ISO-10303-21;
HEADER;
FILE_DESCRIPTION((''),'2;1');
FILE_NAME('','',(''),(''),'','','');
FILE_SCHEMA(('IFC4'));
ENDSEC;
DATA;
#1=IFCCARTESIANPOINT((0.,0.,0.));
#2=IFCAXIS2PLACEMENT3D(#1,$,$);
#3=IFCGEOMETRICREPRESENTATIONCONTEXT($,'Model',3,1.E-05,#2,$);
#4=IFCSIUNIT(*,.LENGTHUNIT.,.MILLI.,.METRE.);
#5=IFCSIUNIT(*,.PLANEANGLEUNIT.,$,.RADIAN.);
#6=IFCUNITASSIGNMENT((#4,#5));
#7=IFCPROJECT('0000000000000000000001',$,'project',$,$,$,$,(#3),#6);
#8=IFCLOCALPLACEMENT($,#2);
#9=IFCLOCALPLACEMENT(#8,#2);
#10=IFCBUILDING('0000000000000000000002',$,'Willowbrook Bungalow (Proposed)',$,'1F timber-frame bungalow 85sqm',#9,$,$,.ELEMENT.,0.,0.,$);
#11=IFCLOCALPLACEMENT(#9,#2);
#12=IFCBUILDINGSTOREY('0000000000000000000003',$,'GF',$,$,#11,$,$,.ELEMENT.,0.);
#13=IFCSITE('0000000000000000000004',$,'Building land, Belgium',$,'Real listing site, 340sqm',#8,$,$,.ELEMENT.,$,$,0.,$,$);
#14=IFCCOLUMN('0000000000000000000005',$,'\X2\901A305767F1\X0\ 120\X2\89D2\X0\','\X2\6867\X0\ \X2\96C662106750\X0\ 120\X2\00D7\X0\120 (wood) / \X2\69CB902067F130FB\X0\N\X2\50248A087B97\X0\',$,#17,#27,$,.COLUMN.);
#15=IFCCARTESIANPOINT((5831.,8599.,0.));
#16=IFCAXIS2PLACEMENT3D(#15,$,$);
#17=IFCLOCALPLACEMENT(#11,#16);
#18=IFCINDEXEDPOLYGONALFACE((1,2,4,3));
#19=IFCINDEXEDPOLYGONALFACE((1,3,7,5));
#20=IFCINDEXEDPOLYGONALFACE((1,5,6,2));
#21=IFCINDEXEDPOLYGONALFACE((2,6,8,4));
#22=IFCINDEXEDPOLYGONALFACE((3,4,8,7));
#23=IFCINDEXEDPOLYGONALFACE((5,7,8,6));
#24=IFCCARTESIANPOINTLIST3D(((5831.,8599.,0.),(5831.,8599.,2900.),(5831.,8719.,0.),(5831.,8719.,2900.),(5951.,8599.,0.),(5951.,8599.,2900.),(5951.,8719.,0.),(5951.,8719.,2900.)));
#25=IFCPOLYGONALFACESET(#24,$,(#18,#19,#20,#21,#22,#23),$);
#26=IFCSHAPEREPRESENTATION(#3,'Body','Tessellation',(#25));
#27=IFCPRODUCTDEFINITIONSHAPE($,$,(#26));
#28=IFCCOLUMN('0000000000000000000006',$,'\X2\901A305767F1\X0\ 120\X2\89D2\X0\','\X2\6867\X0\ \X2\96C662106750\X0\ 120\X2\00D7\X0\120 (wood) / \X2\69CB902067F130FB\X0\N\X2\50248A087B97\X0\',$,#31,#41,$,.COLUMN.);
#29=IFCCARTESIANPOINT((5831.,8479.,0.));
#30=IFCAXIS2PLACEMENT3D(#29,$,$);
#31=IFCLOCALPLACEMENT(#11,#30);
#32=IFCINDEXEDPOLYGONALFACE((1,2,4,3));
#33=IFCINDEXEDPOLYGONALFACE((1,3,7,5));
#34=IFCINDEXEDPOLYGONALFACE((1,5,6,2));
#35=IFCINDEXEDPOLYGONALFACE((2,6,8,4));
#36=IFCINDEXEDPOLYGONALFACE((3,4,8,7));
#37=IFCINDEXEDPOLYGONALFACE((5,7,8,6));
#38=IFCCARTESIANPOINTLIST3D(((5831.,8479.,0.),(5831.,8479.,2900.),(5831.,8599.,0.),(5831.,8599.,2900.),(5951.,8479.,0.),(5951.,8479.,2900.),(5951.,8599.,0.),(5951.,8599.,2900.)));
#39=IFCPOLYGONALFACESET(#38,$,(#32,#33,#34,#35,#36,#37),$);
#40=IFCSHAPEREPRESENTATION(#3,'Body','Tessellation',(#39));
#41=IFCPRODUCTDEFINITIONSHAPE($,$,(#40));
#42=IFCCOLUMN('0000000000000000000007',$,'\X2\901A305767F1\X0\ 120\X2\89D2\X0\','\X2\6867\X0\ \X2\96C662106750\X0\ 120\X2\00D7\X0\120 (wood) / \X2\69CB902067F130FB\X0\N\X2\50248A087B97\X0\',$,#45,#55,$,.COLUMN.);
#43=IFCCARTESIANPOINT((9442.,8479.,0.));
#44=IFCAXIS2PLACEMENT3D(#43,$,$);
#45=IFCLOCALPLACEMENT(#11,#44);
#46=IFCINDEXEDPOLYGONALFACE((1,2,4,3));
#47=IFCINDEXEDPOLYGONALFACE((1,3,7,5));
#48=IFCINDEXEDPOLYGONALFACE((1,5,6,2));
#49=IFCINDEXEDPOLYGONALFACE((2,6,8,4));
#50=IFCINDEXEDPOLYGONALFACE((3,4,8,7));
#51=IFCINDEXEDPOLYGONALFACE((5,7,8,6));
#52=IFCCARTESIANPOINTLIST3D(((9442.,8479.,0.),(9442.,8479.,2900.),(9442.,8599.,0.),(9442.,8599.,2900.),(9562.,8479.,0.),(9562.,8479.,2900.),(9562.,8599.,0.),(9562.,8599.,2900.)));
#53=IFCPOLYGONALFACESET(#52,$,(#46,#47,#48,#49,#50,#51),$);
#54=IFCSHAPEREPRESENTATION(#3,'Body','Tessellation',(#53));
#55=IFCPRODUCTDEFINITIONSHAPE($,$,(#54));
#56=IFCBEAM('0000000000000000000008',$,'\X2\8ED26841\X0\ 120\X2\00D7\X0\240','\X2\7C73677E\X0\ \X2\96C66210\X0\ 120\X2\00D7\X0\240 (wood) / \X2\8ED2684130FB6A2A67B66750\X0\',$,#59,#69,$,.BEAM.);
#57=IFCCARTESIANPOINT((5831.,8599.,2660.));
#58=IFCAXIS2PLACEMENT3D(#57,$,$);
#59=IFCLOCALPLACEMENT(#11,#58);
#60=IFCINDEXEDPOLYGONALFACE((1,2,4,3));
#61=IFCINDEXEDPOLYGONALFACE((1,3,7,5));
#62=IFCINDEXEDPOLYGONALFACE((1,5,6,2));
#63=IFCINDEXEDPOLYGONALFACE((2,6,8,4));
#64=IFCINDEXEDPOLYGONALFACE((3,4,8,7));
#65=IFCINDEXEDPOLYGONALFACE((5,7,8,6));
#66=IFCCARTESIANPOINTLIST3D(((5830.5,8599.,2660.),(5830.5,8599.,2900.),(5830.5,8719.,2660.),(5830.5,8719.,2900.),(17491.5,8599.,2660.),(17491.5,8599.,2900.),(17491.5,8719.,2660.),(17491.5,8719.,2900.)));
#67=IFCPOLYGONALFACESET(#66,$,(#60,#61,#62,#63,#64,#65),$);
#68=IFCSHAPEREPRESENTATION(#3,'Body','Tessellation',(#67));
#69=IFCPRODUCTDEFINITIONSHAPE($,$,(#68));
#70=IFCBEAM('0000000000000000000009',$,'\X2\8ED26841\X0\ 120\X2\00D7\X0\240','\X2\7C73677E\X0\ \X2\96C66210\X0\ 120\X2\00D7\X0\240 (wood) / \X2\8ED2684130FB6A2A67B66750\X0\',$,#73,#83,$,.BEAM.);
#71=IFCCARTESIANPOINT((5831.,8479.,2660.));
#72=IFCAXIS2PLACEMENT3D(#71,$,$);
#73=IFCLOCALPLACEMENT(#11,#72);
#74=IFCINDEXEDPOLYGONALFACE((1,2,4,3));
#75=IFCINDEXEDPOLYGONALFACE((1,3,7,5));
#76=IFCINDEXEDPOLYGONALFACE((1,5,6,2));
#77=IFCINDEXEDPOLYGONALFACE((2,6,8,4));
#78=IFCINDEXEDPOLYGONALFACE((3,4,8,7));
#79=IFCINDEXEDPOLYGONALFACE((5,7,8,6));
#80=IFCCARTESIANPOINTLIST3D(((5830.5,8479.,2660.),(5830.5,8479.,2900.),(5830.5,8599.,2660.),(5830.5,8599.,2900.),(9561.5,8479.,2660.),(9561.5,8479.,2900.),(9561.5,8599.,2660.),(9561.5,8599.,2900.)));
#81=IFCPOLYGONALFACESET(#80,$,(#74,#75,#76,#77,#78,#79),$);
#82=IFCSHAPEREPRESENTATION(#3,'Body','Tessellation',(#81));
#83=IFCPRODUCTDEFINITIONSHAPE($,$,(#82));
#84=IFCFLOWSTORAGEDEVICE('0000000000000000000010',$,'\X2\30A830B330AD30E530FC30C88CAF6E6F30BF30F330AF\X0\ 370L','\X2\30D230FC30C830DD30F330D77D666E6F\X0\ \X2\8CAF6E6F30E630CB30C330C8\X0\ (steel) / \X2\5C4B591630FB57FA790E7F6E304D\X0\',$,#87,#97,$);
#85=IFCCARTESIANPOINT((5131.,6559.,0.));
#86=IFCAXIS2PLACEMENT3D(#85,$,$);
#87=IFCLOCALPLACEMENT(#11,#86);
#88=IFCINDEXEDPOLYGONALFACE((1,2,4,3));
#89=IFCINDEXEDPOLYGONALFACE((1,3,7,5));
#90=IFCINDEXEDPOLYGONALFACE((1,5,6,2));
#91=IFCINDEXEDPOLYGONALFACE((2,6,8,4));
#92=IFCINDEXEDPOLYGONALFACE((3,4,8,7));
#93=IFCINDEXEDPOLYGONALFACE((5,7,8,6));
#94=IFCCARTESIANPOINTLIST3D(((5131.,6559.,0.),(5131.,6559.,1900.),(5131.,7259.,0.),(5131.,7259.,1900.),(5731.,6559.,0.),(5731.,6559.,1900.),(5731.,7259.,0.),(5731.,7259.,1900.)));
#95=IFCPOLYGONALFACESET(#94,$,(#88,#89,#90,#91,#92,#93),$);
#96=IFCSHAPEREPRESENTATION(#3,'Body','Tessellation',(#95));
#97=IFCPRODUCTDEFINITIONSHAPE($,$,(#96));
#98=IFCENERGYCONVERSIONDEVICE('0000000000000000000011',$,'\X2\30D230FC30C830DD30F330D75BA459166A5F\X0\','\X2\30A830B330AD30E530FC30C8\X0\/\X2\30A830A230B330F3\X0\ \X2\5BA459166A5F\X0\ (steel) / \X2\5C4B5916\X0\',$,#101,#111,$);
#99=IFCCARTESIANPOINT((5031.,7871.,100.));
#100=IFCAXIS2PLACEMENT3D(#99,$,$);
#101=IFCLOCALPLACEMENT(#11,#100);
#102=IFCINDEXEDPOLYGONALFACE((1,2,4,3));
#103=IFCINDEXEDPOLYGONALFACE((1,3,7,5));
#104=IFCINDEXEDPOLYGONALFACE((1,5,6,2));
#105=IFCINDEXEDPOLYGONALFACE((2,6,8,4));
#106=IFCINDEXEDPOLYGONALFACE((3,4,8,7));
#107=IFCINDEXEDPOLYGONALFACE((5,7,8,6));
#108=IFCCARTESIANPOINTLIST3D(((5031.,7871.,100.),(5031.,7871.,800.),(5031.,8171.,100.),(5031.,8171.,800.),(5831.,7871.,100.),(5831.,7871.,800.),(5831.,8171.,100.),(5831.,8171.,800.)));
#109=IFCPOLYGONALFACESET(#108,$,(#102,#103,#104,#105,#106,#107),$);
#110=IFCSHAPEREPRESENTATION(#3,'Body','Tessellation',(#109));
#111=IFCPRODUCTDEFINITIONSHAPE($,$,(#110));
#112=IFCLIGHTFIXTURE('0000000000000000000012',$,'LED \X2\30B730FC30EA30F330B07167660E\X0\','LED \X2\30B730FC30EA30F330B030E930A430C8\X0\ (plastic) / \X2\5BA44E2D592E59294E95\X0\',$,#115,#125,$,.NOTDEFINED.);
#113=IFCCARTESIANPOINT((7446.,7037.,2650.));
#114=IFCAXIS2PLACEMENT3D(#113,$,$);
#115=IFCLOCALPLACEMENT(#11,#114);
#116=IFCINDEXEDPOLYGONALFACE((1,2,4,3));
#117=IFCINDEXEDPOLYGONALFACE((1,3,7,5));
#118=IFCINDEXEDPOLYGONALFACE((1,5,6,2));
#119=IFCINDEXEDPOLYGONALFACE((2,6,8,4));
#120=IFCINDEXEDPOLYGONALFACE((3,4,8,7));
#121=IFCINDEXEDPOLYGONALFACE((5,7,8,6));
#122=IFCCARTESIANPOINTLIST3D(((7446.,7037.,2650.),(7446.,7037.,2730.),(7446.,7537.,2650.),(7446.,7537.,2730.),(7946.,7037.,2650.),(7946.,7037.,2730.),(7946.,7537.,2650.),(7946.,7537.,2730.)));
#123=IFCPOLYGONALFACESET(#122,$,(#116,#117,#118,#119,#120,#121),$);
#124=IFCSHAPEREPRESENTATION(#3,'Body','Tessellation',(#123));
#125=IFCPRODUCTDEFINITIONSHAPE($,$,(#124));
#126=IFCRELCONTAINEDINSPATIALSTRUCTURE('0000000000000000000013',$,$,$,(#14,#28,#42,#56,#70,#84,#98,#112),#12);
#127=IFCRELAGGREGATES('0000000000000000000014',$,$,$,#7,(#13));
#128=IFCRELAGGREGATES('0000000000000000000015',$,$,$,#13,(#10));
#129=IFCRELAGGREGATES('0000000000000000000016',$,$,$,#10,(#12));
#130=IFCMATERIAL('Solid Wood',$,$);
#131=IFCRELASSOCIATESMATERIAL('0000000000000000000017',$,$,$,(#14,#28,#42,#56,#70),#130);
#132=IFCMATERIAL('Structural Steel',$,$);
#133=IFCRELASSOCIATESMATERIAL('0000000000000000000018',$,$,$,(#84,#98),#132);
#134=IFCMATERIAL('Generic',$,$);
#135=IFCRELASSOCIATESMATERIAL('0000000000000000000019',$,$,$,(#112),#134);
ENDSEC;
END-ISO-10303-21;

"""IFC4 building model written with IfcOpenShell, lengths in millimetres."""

from ifc_helpers import new_model, si_unit, frame, frame_2d, origin, place, context, project, spatial, rectangle, extrude, material, element, save


model = new_model("IFC4")

# Units and contexts
model_context = context("Model", 3, precision=1e-05, world=origin())
ifc_project = project(units=[si_unit("LENGTHUNIT", "METRE", prefix="MILLI"), si_unit("PLANEANGLEUNIT", "RADIAN")], contexts=[model_context])

# Site, building, storey
site_placement = place(None, origin())
site = spatial("IfcSite", under=ifc_project, at=site_placement, Name="Building land, Belgium", ObjectType="Real listing site, 340sqm", CompositionType="ELEMENT", RefElevation=0.0)
building_placement = place(site_placement, origin())
building = spatial("IfcBuilding", under=site, at=building_placement, Name="Willowbrook Bungalow (Proposed)", ObjectType="1F timber-frame bungalow 85sqm", CompositionType="ELEMENT", ElevationOfRefHeight=0.0, ElevationOfTerrain=0.0)
storey_placement = place(building_placement, origin())
storey = spatial("IfcBuildingStorey", under=building, at=storey_placement, Name="GF", CompositionType="ELEMENT", Elevation=0.0)

# Columns
ifc_material_1 = material(Name="Solid Wood")
column_1_placement = place(storey_placement, frame((5831.0, 8599.0, 0.0)))
element("IfcColumn", 1, at=column_1_placement, inside=storey, material=ifc_material_1, Name="通し柱 120角", Description="桧 集成材 120×120 (wood) / 構造柱・N値計算", PredefinedType="COLUMN", context=model_context, shape_type="SweptSolid", body=[
    extrude(rectangle(XDim=120.0, YDim=120.0, at=frame_2d((60.0, 60.0))), frame((5831.0, 8599.0, 0.0)), (0.0, 0.0, 1.0), 2900.0),
])
column_2_placement = place(storey_placement, frame((5831.0, 8479.0, 0.0)))
element("IfcColumn", 2, at=column_2_placement, inside=storey, material=ifc_material_1, Name="通し柱 120角", Description="桧 集成材 120×120 (wood) / 構造柱・N値計算", PredefinedType="COLUMN", context=model_context, shape_type="SweptSolid", body=[
    extrude(rectangle(XDim=120.0, YDim=120.0, at=frame_2d((60.0, 60.0))), frame((5831.0, 8479.0, 0.0)), (0.0, 0.0, 1.0), 2900.0),
])
column_3_placement = place(storey_placement, frame((9442.0, 8479.0, 0.0)))
element("IfcColumn", 3, at=column_3_placement, inside=storey, material=ifc_material_1, Name="通し柱 120角", Description="桧 集成材 120×120 (wood) / 構造柱・N値計算", PredefinedType="COLUMN", context=model_context, shape_type="SweptSolid", body=[
    extrude(rectangle(XDim=120.0, YDim=120.0, at=frame_2d((60.0, 60.0))), frame((9442.0, 8479.0, 0.0)), (0.0, 0.0, 1.0), 2900.0),
])

# Beams
beam_1_placement = place(storey_placement, frame((5831.0, 8599.0, 2660.0)))
element("IfcBeam", 4, at=beam_1_placement, inside=storey, material=ifc_material_1, Name="軒桁 120×240", Description="米松 集成 120×240 (wood) / 軒桁・横架材", PredefinedType="BEAM", context=model_context, shape_type="SweptSolid", body=[
    extrude(rectangle(XDim=11661.0, YDim=120.0, at=frame_2d((5830.0, 60.0))), frame((5831.0, 8599.0, 2660.0)), (0.0, 0.0, 1.0), 240.0),
])
beam_2_placement = place(storey_placement, frame((5831.0, 8479.0, 2660.0)))
element("IfcBeam", 5, at=beam_2_placement, inside=storey, material=ifc_material_1, Name="軒桁 120×240", Description="米松 集成 120×240 (wood) / 軒桁・横架材", PredefinedType="BEAM", context=model_context, shape_type="SweptSolid", body=[
    extrude(rectangle(XDim=3731.0, YDim=120.0, at=frame_2d((1865.0, 60.0))), frame((5831.0, 8479.0, 2660.0)), (0.0, 0.0, 1.0), 240.0),
])

# Shared definitions
ifc_material_2 = material(Name="Structural Steel")

# Shared definitions
ifc_material_3 = material(Name="Generic")

# Flow storage device
flow_storage_device_placement = place(storey_placement, frame((5131.0, 6559.0, 0.0)))
element("IfcFlowStorageDevice", 6, at=flow_storage_device_placement, inside=storey, material=ifc_material_2, Name="エコキュート貯湯タンク 370L", Description="ヒートポンプ給湯 貯湯ユニット (steel) / 屋外・基礎置き", context=model_context, shape_type="SweptSolid", body=[
    extrude(rectangle(XDim=600.0, YDim=700.0, at=frame_2d((300.0, 350.0))), frame((5131.0, 6559.0, 0.0)), (0.0, 0.0, 1.0), 1900.0),
])

# Energy conversion device
energy_conversion_device_placement = place(storey_placement, frame((5031.0, 7871.0, 100.0)))
element("IfcEnergyConversionDevice", 7, at=energy_conversion_device_placement, inside=storey, material=ifc_material_2, Name="ヒートポンプ室外機", Description="エコキュート/エアコン 室外機 (steel) / 屋外", context=model_context, shape_type="SweptSolid", body=[
    extrude(rectangle(XDim=800.0, YDim=300.0, at=frame_2d((400.0, 150.0))), frame((5031.0, 7871.0, 100.0)), (0.0, 0.0, 1.0), 700.0),
])

# Light fixture
light_fixture_placement = place(storey_placement, frame((7446.0, 7037.0, 2650.0)))
element("IfcLightFixture", 8, at=light_fixture_placement, inside=storey, material=ifc_material_3, Name="LED シーリング照明", Description="LED シーリングライト (plastic) / 室中央天井", PredefinedType="NOTDEFINED", context=model_context, shape_type="SweptSolid", body=[
    extrude(rectangle(XDim=500.0, YDim=500.0, at=frame_2d((250.0, 250.0))), frame((7446.0, 7037.0, 2650.0)), (0.0, 0.0, 1.0), 80.0),
])

save(model, "model.ifc")
